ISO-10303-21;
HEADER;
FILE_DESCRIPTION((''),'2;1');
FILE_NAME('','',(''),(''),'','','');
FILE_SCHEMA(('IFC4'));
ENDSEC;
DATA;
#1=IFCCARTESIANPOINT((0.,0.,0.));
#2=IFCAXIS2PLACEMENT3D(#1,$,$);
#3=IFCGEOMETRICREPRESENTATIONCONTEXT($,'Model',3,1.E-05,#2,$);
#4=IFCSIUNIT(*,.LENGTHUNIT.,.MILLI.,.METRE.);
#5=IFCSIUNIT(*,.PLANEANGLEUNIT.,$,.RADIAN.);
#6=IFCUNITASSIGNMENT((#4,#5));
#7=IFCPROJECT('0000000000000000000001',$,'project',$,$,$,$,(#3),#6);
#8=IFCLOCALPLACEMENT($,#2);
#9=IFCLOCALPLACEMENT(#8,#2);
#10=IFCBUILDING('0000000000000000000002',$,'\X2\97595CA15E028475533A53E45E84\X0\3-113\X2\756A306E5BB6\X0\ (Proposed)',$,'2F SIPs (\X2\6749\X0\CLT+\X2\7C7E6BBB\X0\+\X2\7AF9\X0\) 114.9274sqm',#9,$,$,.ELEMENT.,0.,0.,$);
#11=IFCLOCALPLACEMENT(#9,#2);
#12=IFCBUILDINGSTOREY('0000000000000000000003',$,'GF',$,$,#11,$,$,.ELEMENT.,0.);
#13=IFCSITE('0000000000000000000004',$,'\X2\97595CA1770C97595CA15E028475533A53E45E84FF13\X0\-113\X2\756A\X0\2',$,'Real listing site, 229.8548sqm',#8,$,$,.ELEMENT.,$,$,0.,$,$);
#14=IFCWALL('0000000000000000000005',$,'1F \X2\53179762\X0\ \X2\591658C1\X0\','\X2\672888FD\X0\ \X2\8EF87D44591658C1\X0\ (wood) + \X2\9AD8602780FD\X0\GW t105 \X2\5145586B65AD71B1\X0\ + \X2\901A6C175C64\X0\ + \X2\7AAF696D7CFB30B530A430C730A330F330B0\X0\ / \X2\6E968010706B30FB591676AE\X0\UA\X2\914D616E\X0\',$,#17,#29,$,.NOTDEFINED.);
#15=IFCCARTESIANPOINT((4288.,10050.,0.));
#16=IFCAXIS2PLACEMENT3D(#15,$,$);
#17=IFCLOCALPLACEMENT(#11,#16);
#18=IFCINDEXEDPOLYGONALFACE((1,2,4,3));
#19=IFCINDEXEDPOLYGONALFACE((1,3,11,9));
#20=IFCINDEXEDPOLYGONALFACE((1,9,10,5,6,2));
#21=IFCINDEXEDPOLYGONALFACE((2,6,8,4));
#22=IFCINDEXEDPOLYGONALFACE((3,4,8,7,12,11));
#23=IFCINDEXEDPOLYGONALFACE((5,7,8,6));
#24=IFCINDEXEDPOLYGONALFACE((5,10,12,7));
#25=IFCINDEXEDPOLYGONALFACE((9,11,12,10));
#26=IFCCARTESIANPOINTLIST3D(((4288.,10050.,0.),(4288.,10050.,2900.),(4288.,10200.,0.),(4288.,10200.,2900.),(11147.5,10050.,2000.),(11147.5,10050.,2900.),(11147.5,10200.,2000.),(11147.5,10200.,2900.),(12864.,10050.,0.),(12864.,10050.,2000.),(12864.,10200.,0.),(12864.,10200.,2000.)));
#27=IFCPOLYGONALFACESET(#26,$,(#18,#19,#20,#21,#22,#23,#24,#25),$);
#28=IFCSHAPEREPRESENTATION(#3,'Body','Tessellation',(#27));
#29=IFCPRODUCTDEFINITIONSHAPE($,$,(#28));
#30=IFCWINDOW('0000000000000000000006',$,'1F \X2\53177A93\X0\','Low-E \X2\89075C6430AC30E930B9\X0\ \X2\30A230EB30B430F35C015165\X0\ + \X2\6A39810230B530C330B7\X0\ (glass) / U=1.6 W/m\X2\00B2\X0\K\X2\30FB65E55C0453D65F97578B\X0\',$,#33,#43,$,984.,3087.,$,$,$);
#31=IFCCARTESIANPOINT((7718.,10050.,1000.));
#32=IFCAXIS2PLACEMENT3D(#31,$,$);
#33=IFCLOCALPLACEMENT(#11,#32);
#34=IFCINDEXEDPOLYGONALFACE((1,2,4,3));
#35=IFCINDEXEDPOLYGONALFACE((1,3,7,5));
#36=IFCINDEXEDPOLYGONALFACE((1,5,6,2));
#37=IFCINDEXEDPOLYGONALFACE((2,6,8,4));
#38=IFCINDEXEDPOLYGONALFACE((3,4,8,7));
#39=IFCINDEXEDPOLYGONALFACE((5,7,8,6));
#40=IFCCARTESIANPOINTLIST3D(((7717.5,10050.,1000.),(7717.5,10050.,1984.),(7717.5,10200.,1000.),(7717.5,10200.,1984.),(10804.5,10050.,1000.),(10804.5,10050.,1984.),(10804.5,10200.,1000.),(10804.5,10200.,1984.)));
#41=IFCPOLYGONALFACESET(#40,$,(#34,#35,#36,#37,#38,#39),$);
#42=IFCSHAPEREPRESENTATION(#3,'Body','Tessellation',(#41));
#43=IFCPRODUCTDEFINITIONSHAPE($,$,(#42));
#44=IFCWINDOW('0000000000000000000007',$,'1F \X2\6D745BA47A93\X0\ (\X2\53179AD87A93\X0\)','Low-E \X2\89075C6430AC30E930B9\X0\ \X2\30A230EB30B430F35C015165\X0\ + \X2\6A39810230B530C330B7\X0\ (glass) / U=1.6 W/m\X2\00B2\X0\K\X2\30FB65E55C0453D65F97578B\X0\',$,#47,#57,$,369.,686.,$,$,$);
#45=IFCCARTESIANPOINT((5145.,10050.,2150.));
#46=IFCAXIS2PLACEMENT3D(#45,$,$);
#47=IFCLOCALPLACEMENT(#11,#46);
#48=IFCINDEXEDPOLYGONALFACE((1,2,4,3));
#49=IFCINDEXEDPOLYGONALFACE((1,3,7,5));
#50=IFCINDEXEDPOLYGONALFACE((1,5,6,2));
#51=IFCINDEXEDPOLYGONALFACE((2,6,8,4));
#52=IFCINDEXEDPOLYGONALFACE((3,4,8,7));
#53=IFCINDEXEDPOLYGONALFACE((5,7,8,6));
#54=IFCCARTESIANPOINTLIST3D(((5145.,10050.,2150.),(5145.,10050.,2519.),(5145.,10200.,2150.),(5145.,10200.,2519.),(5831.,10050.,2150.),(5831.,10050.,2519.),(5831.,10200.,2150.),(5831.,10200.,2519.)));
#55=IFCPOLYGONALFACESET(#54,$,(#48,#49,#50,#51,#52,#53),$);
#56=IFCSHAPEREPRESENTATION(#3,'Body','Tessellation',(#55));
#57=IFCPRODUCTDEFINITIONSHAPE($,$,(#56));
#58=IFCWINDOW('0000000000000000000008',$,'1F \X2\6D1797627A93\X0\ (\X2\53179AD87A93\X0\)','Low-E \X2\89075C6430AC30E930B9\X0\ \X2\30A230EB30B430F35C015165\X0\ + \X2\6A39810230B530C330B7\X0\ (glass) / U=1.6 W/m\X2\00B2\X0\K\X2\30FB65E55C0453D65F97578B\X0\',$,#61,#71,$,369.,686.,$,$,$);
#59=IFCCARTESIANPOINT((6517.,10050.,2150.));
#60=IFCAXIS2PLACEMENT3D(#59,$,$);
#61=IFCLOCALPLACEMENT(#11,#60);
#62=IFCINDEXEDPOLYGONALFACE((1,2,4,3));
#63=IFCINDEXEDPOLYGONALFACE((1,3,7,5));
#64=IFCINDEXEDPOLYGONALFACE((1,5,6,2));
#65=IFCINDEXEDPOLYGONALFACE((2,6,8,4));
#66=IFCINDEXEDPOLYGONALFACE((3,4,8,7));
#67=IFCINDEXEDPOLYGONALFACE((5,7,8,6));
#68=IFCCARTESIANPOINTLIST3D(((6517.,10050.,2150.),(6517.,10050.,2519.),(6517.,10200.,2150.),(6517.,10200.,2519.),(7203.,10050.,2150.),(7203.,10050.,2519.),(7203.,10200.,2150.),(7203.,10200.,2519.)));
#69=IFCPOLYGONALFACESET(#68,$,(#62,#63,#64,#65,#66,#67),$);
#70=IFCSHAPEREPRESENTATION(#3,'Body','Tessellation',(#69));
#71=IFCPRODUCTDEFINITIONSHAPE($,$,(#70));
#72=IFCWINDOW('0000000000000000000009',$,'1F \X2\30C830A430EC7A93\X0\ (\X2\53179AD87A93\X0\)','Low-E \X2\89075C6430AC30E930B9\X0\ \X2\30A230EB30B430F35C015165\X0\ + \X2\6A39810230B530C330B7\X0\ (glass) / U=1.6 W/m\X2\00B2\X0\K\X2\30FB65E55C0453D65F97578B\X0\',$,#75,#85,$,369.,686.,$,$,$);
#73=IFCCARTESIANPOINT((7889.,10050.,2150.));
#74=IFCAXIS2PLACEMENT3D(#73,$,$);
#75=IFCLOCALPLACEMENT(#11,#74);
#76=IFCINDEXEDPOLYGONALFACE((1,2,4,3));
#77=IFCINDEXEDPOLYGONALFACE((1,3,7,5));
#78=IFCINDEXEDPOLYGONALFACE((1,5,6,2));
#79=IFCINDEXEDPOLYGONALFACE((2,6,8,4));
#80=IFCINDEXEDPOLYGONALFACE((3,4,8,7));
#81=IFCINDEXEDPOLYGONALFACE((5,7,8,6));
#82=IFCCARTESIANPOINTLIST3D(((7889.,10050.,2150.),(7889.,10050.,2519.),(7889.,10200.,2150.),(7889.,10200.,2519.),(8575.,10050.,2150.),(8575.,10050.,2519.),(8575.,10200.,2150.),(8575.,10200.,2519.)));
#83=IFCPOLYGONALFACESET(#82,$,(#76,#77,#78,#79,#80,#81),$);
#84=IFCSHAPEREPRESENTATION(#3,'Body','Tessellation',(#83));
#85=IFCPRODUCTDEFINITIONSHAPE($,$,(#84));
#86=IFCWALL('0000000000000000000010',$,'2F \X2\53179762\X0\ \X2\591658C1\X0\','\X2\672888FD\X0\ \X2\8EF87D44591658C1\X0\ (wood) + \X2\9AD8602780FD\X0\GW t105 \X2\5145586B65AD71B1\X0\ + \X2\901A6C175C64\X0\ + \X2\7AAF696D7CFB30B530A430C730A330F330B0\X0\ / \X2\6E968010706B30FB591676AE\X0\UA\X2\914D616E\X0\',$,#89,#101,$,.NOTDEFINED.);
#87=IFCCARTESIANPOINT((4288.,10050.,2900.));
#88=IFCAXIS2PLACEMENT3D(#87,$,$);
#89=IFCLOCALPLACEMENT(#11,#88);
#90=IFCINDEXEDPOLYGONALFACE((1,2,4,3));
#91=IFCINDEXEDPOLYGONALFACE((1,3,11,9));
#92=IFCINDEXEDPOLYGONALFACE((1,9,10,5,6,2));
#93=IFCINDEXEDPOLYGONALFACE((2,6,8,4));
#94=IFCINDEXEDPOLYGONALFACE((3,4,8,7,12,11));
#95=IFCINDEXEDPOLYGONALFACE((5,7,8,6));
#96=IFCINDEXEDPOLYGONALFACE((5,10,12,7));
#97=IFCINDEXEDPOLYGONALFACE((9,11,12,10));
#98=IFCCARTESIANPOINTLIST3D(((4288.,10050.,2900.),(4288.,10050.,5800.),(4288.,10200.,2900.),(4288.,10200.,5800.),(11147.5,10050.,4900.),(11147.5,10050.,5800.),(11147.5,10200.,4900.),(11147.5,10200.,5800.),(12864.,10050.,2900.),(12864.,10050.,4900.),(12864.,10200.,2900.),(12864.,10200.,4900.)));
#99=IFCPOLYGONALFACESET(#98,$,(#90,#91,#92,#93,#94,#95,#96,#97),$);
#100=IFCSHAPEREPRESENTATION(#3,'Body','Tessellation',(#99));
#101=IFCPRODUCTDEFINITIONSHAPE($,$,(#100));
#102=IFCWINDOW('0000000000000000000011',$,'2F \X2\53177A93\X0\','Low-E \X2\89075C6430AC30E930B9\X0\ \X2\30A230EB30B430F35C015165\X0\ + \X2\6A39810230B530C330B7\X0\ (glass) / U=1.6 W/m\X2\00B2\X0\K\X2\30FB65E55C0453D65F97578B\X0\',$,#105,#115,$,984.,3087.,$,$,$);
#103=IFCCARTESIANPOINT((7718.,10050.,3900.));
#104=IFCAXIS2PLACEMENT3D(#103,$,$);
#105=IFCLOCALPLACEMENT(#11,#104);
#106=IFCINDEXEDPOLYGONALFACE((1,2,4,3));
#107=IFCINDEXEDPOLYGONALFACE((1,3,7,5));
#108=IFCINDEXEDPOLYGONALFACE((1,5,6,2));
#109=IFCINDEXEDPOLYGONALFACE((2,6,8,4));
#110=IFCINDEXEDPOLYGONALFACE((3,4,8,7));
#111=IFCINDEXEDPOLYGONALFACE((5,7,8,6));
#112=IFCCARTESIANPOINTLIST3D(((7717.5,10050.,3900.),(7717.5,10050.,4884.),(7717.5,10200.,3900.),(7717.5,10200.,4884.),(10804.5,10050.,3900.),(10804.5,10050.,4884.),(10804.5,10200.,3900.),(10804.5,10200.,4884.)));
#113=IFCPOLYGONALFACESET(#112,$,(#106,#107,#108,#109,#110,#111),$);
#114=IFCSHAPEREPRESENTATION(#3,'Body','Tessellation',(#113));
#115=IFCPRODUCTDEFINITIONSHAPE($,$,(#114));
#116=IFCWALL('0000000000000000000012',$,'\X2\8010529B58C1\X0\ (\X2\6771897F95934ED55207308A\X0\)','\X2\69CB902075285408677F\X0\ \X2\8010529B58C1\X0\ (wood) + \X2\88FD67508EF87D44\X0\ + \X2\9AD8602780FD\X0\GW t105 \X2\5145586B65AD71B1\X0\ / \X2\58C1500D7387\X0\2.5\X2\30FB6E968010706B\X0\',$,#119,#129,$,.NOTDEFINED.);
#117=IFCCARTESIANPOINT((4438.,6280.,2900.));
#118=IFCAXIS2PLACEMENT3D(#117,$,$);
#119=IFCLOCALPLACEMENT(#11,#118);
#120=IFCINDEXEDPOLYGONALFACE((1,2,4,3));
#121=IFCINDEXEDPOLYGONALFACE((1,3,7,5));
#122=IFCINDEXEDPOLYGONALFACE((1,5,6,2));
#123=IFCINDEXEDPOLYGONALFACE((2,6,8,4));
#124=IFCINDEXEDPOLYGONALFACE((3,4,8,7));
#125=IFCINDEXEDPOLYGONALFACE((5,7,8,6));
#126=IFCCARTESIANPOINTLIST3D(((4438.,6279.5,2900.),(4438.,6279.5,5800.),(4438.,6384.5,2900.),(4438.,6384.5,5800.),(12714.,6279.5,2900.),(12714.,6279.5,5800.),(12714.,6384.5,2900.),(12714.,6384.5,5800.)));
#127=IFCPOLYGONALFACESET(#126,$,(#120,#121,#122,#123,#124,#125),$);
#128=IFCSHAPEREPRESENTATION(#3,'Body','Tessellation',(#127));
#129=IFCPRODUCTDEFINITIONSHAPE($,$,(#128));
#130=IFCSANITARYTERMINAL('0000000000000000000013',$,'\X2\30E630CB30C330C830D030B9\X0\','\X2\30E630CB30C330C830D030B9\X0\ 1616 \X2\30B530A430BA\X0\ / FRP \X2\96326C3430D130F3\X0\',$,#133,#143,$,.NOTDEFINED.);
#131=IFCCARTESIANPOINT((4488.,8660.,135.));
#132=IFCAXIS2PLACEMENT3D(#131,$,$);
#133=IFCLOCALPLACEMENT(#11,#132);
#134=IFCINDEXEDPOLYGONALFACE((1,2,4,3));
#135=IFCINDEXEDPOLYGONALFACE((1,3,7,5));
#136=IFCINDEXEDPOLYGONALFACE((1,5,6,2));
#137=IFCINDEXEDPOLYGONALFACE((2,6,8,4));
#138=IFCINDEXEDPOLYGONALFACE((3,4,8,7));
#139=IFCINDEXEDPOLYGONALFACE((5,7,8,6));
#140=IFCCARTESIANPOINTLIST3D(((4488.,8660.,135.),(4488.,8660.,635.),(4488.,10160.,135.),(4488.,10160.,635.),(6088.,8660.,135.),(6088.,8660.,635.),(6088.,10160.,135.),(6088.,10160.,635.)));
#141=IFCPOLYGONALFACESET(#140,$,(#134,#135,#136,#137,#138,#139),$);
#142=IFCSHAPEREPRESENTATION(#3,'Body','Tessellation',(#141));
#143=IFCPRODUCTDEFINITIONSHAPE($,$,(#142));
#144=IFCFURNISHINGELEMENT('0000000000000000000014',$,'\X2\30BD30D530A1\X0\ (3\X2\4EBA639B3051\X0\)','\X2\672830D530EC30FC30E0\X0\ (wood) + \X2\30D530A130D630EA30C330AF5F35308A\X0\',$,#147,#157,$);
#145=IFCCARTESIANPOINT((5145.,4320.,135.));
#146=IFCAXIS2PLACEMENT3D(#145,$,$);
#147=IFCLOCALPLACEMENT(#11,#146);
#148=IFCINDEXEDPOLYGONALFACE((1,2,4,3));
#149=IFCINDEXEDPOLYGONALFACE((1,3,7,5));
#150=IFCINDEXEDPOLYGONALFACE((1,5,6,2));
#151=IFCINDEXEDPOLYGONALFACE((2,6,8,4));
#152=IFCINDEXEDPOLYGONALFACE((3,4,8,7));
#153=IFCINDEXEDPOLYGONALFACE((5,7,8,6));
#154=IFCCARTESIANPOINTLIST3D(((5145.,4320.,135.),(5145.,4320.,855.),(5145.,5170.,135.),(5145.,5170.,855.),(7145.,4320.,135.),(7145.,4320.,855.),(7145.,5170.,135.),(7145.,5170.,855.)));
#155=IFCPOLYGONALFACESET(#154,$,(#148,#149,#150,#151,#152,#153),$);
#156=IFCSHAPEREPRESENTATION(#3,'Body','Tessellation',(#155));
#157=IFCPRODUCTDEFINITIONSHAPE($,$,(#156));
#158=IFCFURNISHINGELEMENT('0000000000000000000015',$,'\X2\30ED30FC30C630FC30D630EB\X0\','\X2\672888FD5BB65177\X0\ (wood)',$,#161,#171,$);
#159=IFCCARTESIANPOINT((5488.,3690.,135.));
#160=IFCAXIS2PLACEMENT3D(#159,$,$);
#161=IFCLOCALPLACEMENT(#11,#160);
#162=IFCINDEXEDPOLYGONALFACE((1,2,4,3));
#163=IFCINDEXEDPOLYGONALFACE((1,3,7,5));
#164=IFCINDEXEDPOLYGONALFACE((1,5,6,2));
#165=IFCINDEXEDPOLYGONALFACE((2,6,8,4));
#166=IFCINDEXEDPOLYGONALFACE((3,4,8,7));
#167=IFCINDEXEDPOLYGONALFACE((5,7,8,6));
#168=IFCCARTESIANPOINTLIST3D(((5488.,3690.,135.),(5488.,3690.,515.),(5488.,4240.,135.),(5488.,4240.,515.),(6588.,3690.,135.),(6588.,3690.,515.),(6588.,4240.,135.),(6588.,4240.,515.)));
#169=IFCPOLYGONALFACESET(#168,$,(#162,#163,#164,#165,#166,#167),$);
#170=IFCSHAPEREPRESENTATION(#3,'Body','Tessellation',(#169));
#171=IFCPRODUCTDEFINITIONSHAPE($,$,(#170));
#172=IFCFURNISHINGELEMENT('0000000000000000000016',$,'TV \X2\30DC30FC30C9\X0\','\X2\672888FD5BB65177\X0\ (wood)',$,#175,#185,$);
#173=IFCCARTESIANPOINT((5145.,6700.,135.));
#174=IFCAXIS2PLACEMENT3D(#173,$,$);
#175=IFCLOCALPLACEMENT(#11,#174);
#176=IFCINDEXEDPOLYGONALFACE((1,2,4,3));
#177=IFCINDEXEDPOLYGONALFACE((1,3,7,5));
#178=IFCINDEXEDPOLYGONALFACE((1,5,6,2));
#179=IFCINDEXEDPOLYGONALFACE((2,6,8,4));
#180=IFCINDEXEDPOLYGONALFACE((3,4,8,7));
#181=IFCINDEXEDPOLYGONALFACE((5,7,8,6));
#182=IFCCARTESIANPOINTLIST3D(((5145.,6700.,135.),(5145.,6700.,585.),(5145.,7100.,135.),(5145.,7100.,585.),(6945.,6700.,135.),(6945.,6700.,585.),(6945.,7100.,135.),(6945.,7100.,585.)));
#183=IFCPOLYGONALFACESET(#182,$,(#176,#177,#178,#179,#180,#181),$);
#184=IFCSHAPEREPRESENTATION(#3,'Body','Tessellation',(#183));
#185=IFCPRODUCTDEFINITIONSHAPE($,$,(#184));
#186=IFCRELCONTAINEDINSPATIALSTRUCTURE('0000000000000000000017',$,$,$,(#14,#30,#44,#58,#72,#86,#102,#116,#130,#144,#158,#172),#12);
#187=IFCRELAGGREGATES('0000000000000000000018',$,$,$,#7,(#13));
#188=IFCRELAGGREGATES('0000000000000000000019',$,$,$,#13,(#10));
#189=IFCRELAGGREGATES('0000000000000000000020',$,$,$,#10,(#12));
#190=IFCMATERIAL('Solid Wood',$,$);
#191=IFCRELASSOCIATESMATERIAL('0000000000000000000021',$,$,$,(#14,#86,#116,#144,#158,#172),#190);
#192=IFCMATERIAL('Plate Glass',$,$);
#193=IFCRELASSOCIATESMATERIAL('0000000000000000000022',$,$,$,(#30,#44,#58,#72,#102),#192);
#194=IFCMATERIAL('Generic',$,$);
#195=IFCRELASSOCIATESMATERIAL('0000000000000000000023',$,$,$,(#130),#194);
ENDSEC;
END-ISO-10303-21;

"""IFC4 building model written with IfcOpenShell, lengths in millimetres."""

from ifc_helpers import new_model, si_unit, frame, frame_2d, origin, place, context, project, spatial, rectangle, extrude, material, element, fill, save


model = new_model("IFC4")

# Units and contexts
model_context = context("Model", 3, precision=1e-05, world=origin())
ifc_project = project(units=[si_unit("LENGTHUNIT", "METRE", prefix="MILLI"), si_unit("PLANEANGLEUNIT", "RADIAN")], contexts=[model_context])

# Site, building, storey
site_placement = place(None, origin())
site = spatial("IfcSite", under=ifc_project, at=site_placement, Name="静岡県静岡市葵区古庄３-113番2", ObjectType="Real listing site, 229.8548sqm", CompositionType="ELEMENT", RefElevation=0.0)
building_placement = place(site_placement, origin())
building = spatial("IfcBuilding", under=site, at=building_placement, Name="静岡市葵区古庄3-113番の家 (Proposed)", ObjectType="2F SIPs (杉CLT+籾殻+竹) 114.9274sqm", CompositionType="ELEMENT", ElevationOfRefHeight=0.0, ElevationOfTerrain=0.0)
storey_placement = place(building_placement, origin())
storey = spatial("IfcBuildingStorey", under=building, at=storey_placement, Name="GF", CompositionType="ELEMENT", Elevation=0.0)

# Wall, openings, windows
ifc_material_1 = material(Name="Solid Wood")
wall_1_placement = place(storey_placement, frame((4288.0, 10050.0, 0.0)))
wall_1 = element("IfcWall", 1, at=wall_1_placement, inside=storey, material=ifc_material_1, Name="1F 北面 外壁", Description="木製 軸組外壁 (wood) + 高性能GW t105 充填断熱 + 通気層 + 窯業系サイディング / 準耐火・外皮UA配慮", PredefinedType="NOTDEFINED", context=model_context, shape_type="SweptSolid", body=[
    extrude(rectangle(XDim=8576.0, YDim=150.0, at=frame_2d((4288.0, 75.0))), frame((4288.0, 10050.0, 0.0)), (0.0, 0.0, 1.0), 2900.0),
])
opening_1_placement = place(storey_placement, frame((7718.0, 10050.0, 1000.0)))
opening_1 = element("IfcOpeningElement", 2, at=opening_1_placement, cuts=wall_1, PredefinedType="NOTDEFINED", context=model_context, shape_type="SweptSolid", body=[
    extrude(rectangle(XDim=3087.0, YDim=150.0, at=frame_2d((1543.0, 75.0))), frame((7718.0, 10050.0, 1000.0)), (0.0, 0.0, 1.0), 984.0),
])
opening_2_placement = place(storey_placement, frame((5145.0, 10050.0, 2150.0)))
opening_2 = element("IfcOpeningElement", 3, at=opening_2_placement, cuts=wall_1, PredefinedType="NOTDEFINED", context=model_context, shape_type="SweptSolid", body=[
    extrude(rectangle(XDim=686.0, YDim=150.0, at=frame_2d((343.0, 75.0))), frame((5145.0, 10050.0, 2150.0)), (0.0, 0.0, 1.0), 369.0),
])
opening_3_placement = place(storey_placement, frame((6517.0, 10050.0, 2150.0)))
opening_3 = element("IfcOpeningElement", 4, at=opening_3_placement, cuts=wall_1, PredefinedType="NOTDEFINED", context=model_context, shape_type="SweptSolid", body=[
    extrude(rectangle(XDim=686.0, YDim=150.0, at=frame_2d((343.0, 75.0))), frame((6517.0, 10050.0, 2150.0)), (0.0, 0.0, 1.0), 369.0),
])
opening_4_placement = place(storey_placement, frame((7889.0, 10050.0, 2150.0)))
opening_4 = element("IfcOpeningElement", 5, at=opening_4_placement, cuts=wall_1, PredefinedType="NOTDEFINED", context=model_context, shape_type="SweptSolid", body=[
    extrude(rectangle(XDim=686.0, YDim=150.0, at=frame_2d((343.0, 75.0))), frame((7889.0, 10050.0, 2150.0)), (0.0, 0.0, 1.0), 369.0),
])
ifc_material_2 = material(Name="Plate Glass")
window_1_placement = place(storey_placement, frame((7718.0, 10050.0, 1000.0)))
window_1 = element("IfcWindow", 6, at=window_1_placement, inside=storey, material=ifc_material_2, Name="1F 北窓", Description="Low-E 複層ガラス アルゴン封入 + 樹脂サッシ (glass) / U=1.6 W/m²K・日射取得型", OverallHeight=984.0, OverallWidth=3087.0, context=model_context, shape_type="SweptSolid", body=[
    extrude(rectangle(XDim=3087.0, YDim=150.0, at=frame_2d((1543.0, 75.0))), frame((7718.0, 10050.0, 1000.0)), (0.0, 0.0, 1.0), 984.0),
])
fill(opening_1, window_1)
window_2_placement = place(storey_placement, frame((5145.0, 10050.0, 2150.0)))
window_2 = element("IfcWindow", 7, at=window_2_placement, inside=storey, material=ifc_material_2, Name="1F 浴室窓 (北高窓)", Description="Low-E 複層ガラス アルゴン封入 + 樹脂サッシ (glass) / U=1.6 W/m²K・日射取得型", OverallHeight=369.0, OverallWidth=686.0, context=model_context, shape_type="SweptSolid", body=[
    extrude(rectangle(XDim=686.0, YDim=150.0, at=frame_2d((343.0, 75.0))), frame((5145.0, 10050.0, 2150.0)), (0.0, 0.0, 1.0), 369.0),
])
fill(opening_2, window_2)
window_3_placement = place(storey_placement, frame((6517.0, 10050.0, 2150.0)))
window_3 = element("IfcWindow", 8, at=window_3_placement, inside=storey, material=ifc_material_2, Name="1F 洗面窓 (北高窓)", Description="Low-E 複層ガラス アルゴン封入 + 樹脂サッシ (glass) / U=1.6 W/m²K・日射取得型", OverallHeight=369.0, OverallWidth=686.0, context=model_context, shape_type="SweptSolid", body=[
    extrude(rectangle(XDim=686.0, YDim=150.0, at=frame_2d((343.0, 75.0))), frame((6517.0, 10050.0, 2150.0)), (0.0, 0.0, 1.0), 369.0),
])
fill(opening_3, window_3)
window_4_placement = place(storey_placement, frame((7889.0, 10050.0, 2150.0)))
window_4 = element("IfcWindow", 9, at=window_4_placement, inside=storey, material=ifc_material_2, Name="1F トイレ窓 (北高窓)", Description="Low-E 複層ガラス アルゴン封入 + 樹脂サッシ (glass) / U=1.6 W/m²K・日射取得型", OverallHeight=369.0, OverallWidth=686.0, context=model_context, shape_type="SweptSolid", body=[
    extrude(rectangle(XDim=686.0, YDim=150.0, at=frame_2d((343.0, 75.0))), frame((7889.0, 10050.0, 2150.0)), (0.0, 0.0, 1.0), 369.0),
])
fill(opening_4, window_4)

# Wall, opening, window
wall_2_placement = place(storey_placement, frame((4288.0, 10050.0, 2900.0)))
wall_2 = element("IfcWall", 10, at=wall_2_placement, inside=storey, material=ifc_material_1, Name="2F 北面 外壁", Description="木製 軸組外壁 (wood) + 高性能GW t105 充填断熱 + 通気層 + 窯業系サイディング / 準耐火・外皮UA配慮", PredefinedType="NOTDEFINED", context=model_context, shape_type="SweptSolid", body=[
    extrude(rectangle(XDim=8576.0, YDim=150.0, at=frame_2d((4288.0, 75.0))), frame((4288.0, 10050.0, 2900.0)), (0.0, 0.0, 1.0), 2900.0),
])
opening_5_placement = place(storey_placement, frame((7718.0, 10050.0, 3900.0)))
opening_5 = element("IfcOpeningElement", 11, at=opening_5_placement, cuts=wall_2, PredefinedType="NOTDEFINED", context=model_context, shape_type="SweptSolid", body=[
    extrude(rectangle(XDim=3087.0, YDim=150.0, at=frame_2d((1543.0, 75.0))), frame((7718.0, 10050.0, 3900.0)), (0.0, 0.0, 1.0), 984.0),
])
window_5_placement = place(storey_placement, frame((7718.0, 10050.0, 3900.0)))
window_5 = element("IfcWindow", 12, at=window_5_placement, inside=storey, material=ifc_material_2, Name="2F 北窓", Description="Low-E 複層ガラス アルゴン封入 + 樹脂サッシ (glass) / U=1.6 W/m²K・日射取得型", OverallHeight=984.0, OverallWidth=3087.0, context=model_context, shape_type="SweptSolid", body=[
    extrude(rectangle(XDim=3087.0, YDim=150.0, at=frame_2d((1543.0, 75.0))), frame((7718.0, 10050.0, 3900.0)), (0.0, 0.0, 1.0), 984.0),
])
fill(opening_5, window_5)

# Wall
wall_3_placement = place(storey_placement, frame((4438.0, 6280.0, 2900.0)))
element("IfcWall", 13, at=wall_3_placement, inside=storey, material=ifc_material_1, Name="耐力壁 (東西間仕切り)", Description="構造用合板 耐力壁 (wood) + 製材軸組 + 高性能GW t105 充填断熱 / 壁倍率2.5・準耐火", PredefinedType="NOTDEFINED", context=model_context, shape_type="SweptSolid", body=[
    extrude(rectangle(XDim=8276.0, YDim=105.0, at=frame_2d((4138.0, 52.0))), frame((4438.0, 6280.0, 2900.0)), (0.0, 0.0, 1.0), 2900.0),
])

# Sanitary terminal
ifc_material_3 = material(Name="Generic")
sanitary_terminal_placement = place(storey_placement, frame((4488.0, 8660.0, 135.0)))
element("IfcSanitaryTerminal", 14, at=sanitary_terminal_placement, inside=storey, material=ifc_material_3, Name="ユニットバス", Description="ユニットバス 1616 サイズ / FRP 防水パン", PredefinedType="NOTDEFINED", context=model_context, shape_type="SweptSolid", body=[
    extrude(rectangle(XDim=1600.0, YDim=1500.0, at=frame_2d((800.0, 750.0))), frame((4488.0, 8660.0, 135.0)), (0.0, 0.0, 1.0), 500.0),
])

# Furnishing elements
furnishing_1_placement = place(storey_placement, frame((5145.0, 4320.0, 135.0)))
element("IfcFurnishingElement", 15, at=furnishing_1_placement, inside=storey, material=ifc_material_1, Name="ソファ (3人掛け)", Description="木フレーム (wood) + ファブリック張り", context=model_context, shape_type="SweptSolid", body=[
    extrude(rectangle(XDim=2000.0, YDim=850.0, at=frame_2d((1000.0, 425.0))), frame((5145.0, 4320.0, 135.0)), (0.0, 0.0, 1.0), 720.0),
])
furnishing_2_placement = place(storey_placement, frame((5488.0, 3690.0, 135.0)))
element("IfcFurnishingElement", 16, at=furnishing_2_placement, inside=storey, material=ifc_material_1, Name="ローテーブル", Description="木製家具 (wood)", context=model_context, shape_type="SweptSolid", body=[
    extrude(rectangle(XDim=1100.0, YDim=550.0, at=frame_2d((550.0, 275.0))), frame((5488.0, 3690.0, 135.0)), (0.0, 0.0, 1.0), 380.0),
])
furnishing_3_placement = place(storey_placement, frame((5145.0, 6700.0, 135.0)))
element("IfcFurnishingElement", 17, at=furnishing_3_placement, inside=storey, material=ifc_material_1, Name="TV ボード", Description="木製家具 (wood)", context=model_context, shape_type="SweptSolid", body=[
    extrude(rectangle(XDim=1800.0, YDim=400.0, at=frame_2d((900.0, 200.0))), frame((5145.0, 6700.0, 135.0)), (0.0, 0.0, 1.0), 450.0),
])

save(model, "model.ifc")
